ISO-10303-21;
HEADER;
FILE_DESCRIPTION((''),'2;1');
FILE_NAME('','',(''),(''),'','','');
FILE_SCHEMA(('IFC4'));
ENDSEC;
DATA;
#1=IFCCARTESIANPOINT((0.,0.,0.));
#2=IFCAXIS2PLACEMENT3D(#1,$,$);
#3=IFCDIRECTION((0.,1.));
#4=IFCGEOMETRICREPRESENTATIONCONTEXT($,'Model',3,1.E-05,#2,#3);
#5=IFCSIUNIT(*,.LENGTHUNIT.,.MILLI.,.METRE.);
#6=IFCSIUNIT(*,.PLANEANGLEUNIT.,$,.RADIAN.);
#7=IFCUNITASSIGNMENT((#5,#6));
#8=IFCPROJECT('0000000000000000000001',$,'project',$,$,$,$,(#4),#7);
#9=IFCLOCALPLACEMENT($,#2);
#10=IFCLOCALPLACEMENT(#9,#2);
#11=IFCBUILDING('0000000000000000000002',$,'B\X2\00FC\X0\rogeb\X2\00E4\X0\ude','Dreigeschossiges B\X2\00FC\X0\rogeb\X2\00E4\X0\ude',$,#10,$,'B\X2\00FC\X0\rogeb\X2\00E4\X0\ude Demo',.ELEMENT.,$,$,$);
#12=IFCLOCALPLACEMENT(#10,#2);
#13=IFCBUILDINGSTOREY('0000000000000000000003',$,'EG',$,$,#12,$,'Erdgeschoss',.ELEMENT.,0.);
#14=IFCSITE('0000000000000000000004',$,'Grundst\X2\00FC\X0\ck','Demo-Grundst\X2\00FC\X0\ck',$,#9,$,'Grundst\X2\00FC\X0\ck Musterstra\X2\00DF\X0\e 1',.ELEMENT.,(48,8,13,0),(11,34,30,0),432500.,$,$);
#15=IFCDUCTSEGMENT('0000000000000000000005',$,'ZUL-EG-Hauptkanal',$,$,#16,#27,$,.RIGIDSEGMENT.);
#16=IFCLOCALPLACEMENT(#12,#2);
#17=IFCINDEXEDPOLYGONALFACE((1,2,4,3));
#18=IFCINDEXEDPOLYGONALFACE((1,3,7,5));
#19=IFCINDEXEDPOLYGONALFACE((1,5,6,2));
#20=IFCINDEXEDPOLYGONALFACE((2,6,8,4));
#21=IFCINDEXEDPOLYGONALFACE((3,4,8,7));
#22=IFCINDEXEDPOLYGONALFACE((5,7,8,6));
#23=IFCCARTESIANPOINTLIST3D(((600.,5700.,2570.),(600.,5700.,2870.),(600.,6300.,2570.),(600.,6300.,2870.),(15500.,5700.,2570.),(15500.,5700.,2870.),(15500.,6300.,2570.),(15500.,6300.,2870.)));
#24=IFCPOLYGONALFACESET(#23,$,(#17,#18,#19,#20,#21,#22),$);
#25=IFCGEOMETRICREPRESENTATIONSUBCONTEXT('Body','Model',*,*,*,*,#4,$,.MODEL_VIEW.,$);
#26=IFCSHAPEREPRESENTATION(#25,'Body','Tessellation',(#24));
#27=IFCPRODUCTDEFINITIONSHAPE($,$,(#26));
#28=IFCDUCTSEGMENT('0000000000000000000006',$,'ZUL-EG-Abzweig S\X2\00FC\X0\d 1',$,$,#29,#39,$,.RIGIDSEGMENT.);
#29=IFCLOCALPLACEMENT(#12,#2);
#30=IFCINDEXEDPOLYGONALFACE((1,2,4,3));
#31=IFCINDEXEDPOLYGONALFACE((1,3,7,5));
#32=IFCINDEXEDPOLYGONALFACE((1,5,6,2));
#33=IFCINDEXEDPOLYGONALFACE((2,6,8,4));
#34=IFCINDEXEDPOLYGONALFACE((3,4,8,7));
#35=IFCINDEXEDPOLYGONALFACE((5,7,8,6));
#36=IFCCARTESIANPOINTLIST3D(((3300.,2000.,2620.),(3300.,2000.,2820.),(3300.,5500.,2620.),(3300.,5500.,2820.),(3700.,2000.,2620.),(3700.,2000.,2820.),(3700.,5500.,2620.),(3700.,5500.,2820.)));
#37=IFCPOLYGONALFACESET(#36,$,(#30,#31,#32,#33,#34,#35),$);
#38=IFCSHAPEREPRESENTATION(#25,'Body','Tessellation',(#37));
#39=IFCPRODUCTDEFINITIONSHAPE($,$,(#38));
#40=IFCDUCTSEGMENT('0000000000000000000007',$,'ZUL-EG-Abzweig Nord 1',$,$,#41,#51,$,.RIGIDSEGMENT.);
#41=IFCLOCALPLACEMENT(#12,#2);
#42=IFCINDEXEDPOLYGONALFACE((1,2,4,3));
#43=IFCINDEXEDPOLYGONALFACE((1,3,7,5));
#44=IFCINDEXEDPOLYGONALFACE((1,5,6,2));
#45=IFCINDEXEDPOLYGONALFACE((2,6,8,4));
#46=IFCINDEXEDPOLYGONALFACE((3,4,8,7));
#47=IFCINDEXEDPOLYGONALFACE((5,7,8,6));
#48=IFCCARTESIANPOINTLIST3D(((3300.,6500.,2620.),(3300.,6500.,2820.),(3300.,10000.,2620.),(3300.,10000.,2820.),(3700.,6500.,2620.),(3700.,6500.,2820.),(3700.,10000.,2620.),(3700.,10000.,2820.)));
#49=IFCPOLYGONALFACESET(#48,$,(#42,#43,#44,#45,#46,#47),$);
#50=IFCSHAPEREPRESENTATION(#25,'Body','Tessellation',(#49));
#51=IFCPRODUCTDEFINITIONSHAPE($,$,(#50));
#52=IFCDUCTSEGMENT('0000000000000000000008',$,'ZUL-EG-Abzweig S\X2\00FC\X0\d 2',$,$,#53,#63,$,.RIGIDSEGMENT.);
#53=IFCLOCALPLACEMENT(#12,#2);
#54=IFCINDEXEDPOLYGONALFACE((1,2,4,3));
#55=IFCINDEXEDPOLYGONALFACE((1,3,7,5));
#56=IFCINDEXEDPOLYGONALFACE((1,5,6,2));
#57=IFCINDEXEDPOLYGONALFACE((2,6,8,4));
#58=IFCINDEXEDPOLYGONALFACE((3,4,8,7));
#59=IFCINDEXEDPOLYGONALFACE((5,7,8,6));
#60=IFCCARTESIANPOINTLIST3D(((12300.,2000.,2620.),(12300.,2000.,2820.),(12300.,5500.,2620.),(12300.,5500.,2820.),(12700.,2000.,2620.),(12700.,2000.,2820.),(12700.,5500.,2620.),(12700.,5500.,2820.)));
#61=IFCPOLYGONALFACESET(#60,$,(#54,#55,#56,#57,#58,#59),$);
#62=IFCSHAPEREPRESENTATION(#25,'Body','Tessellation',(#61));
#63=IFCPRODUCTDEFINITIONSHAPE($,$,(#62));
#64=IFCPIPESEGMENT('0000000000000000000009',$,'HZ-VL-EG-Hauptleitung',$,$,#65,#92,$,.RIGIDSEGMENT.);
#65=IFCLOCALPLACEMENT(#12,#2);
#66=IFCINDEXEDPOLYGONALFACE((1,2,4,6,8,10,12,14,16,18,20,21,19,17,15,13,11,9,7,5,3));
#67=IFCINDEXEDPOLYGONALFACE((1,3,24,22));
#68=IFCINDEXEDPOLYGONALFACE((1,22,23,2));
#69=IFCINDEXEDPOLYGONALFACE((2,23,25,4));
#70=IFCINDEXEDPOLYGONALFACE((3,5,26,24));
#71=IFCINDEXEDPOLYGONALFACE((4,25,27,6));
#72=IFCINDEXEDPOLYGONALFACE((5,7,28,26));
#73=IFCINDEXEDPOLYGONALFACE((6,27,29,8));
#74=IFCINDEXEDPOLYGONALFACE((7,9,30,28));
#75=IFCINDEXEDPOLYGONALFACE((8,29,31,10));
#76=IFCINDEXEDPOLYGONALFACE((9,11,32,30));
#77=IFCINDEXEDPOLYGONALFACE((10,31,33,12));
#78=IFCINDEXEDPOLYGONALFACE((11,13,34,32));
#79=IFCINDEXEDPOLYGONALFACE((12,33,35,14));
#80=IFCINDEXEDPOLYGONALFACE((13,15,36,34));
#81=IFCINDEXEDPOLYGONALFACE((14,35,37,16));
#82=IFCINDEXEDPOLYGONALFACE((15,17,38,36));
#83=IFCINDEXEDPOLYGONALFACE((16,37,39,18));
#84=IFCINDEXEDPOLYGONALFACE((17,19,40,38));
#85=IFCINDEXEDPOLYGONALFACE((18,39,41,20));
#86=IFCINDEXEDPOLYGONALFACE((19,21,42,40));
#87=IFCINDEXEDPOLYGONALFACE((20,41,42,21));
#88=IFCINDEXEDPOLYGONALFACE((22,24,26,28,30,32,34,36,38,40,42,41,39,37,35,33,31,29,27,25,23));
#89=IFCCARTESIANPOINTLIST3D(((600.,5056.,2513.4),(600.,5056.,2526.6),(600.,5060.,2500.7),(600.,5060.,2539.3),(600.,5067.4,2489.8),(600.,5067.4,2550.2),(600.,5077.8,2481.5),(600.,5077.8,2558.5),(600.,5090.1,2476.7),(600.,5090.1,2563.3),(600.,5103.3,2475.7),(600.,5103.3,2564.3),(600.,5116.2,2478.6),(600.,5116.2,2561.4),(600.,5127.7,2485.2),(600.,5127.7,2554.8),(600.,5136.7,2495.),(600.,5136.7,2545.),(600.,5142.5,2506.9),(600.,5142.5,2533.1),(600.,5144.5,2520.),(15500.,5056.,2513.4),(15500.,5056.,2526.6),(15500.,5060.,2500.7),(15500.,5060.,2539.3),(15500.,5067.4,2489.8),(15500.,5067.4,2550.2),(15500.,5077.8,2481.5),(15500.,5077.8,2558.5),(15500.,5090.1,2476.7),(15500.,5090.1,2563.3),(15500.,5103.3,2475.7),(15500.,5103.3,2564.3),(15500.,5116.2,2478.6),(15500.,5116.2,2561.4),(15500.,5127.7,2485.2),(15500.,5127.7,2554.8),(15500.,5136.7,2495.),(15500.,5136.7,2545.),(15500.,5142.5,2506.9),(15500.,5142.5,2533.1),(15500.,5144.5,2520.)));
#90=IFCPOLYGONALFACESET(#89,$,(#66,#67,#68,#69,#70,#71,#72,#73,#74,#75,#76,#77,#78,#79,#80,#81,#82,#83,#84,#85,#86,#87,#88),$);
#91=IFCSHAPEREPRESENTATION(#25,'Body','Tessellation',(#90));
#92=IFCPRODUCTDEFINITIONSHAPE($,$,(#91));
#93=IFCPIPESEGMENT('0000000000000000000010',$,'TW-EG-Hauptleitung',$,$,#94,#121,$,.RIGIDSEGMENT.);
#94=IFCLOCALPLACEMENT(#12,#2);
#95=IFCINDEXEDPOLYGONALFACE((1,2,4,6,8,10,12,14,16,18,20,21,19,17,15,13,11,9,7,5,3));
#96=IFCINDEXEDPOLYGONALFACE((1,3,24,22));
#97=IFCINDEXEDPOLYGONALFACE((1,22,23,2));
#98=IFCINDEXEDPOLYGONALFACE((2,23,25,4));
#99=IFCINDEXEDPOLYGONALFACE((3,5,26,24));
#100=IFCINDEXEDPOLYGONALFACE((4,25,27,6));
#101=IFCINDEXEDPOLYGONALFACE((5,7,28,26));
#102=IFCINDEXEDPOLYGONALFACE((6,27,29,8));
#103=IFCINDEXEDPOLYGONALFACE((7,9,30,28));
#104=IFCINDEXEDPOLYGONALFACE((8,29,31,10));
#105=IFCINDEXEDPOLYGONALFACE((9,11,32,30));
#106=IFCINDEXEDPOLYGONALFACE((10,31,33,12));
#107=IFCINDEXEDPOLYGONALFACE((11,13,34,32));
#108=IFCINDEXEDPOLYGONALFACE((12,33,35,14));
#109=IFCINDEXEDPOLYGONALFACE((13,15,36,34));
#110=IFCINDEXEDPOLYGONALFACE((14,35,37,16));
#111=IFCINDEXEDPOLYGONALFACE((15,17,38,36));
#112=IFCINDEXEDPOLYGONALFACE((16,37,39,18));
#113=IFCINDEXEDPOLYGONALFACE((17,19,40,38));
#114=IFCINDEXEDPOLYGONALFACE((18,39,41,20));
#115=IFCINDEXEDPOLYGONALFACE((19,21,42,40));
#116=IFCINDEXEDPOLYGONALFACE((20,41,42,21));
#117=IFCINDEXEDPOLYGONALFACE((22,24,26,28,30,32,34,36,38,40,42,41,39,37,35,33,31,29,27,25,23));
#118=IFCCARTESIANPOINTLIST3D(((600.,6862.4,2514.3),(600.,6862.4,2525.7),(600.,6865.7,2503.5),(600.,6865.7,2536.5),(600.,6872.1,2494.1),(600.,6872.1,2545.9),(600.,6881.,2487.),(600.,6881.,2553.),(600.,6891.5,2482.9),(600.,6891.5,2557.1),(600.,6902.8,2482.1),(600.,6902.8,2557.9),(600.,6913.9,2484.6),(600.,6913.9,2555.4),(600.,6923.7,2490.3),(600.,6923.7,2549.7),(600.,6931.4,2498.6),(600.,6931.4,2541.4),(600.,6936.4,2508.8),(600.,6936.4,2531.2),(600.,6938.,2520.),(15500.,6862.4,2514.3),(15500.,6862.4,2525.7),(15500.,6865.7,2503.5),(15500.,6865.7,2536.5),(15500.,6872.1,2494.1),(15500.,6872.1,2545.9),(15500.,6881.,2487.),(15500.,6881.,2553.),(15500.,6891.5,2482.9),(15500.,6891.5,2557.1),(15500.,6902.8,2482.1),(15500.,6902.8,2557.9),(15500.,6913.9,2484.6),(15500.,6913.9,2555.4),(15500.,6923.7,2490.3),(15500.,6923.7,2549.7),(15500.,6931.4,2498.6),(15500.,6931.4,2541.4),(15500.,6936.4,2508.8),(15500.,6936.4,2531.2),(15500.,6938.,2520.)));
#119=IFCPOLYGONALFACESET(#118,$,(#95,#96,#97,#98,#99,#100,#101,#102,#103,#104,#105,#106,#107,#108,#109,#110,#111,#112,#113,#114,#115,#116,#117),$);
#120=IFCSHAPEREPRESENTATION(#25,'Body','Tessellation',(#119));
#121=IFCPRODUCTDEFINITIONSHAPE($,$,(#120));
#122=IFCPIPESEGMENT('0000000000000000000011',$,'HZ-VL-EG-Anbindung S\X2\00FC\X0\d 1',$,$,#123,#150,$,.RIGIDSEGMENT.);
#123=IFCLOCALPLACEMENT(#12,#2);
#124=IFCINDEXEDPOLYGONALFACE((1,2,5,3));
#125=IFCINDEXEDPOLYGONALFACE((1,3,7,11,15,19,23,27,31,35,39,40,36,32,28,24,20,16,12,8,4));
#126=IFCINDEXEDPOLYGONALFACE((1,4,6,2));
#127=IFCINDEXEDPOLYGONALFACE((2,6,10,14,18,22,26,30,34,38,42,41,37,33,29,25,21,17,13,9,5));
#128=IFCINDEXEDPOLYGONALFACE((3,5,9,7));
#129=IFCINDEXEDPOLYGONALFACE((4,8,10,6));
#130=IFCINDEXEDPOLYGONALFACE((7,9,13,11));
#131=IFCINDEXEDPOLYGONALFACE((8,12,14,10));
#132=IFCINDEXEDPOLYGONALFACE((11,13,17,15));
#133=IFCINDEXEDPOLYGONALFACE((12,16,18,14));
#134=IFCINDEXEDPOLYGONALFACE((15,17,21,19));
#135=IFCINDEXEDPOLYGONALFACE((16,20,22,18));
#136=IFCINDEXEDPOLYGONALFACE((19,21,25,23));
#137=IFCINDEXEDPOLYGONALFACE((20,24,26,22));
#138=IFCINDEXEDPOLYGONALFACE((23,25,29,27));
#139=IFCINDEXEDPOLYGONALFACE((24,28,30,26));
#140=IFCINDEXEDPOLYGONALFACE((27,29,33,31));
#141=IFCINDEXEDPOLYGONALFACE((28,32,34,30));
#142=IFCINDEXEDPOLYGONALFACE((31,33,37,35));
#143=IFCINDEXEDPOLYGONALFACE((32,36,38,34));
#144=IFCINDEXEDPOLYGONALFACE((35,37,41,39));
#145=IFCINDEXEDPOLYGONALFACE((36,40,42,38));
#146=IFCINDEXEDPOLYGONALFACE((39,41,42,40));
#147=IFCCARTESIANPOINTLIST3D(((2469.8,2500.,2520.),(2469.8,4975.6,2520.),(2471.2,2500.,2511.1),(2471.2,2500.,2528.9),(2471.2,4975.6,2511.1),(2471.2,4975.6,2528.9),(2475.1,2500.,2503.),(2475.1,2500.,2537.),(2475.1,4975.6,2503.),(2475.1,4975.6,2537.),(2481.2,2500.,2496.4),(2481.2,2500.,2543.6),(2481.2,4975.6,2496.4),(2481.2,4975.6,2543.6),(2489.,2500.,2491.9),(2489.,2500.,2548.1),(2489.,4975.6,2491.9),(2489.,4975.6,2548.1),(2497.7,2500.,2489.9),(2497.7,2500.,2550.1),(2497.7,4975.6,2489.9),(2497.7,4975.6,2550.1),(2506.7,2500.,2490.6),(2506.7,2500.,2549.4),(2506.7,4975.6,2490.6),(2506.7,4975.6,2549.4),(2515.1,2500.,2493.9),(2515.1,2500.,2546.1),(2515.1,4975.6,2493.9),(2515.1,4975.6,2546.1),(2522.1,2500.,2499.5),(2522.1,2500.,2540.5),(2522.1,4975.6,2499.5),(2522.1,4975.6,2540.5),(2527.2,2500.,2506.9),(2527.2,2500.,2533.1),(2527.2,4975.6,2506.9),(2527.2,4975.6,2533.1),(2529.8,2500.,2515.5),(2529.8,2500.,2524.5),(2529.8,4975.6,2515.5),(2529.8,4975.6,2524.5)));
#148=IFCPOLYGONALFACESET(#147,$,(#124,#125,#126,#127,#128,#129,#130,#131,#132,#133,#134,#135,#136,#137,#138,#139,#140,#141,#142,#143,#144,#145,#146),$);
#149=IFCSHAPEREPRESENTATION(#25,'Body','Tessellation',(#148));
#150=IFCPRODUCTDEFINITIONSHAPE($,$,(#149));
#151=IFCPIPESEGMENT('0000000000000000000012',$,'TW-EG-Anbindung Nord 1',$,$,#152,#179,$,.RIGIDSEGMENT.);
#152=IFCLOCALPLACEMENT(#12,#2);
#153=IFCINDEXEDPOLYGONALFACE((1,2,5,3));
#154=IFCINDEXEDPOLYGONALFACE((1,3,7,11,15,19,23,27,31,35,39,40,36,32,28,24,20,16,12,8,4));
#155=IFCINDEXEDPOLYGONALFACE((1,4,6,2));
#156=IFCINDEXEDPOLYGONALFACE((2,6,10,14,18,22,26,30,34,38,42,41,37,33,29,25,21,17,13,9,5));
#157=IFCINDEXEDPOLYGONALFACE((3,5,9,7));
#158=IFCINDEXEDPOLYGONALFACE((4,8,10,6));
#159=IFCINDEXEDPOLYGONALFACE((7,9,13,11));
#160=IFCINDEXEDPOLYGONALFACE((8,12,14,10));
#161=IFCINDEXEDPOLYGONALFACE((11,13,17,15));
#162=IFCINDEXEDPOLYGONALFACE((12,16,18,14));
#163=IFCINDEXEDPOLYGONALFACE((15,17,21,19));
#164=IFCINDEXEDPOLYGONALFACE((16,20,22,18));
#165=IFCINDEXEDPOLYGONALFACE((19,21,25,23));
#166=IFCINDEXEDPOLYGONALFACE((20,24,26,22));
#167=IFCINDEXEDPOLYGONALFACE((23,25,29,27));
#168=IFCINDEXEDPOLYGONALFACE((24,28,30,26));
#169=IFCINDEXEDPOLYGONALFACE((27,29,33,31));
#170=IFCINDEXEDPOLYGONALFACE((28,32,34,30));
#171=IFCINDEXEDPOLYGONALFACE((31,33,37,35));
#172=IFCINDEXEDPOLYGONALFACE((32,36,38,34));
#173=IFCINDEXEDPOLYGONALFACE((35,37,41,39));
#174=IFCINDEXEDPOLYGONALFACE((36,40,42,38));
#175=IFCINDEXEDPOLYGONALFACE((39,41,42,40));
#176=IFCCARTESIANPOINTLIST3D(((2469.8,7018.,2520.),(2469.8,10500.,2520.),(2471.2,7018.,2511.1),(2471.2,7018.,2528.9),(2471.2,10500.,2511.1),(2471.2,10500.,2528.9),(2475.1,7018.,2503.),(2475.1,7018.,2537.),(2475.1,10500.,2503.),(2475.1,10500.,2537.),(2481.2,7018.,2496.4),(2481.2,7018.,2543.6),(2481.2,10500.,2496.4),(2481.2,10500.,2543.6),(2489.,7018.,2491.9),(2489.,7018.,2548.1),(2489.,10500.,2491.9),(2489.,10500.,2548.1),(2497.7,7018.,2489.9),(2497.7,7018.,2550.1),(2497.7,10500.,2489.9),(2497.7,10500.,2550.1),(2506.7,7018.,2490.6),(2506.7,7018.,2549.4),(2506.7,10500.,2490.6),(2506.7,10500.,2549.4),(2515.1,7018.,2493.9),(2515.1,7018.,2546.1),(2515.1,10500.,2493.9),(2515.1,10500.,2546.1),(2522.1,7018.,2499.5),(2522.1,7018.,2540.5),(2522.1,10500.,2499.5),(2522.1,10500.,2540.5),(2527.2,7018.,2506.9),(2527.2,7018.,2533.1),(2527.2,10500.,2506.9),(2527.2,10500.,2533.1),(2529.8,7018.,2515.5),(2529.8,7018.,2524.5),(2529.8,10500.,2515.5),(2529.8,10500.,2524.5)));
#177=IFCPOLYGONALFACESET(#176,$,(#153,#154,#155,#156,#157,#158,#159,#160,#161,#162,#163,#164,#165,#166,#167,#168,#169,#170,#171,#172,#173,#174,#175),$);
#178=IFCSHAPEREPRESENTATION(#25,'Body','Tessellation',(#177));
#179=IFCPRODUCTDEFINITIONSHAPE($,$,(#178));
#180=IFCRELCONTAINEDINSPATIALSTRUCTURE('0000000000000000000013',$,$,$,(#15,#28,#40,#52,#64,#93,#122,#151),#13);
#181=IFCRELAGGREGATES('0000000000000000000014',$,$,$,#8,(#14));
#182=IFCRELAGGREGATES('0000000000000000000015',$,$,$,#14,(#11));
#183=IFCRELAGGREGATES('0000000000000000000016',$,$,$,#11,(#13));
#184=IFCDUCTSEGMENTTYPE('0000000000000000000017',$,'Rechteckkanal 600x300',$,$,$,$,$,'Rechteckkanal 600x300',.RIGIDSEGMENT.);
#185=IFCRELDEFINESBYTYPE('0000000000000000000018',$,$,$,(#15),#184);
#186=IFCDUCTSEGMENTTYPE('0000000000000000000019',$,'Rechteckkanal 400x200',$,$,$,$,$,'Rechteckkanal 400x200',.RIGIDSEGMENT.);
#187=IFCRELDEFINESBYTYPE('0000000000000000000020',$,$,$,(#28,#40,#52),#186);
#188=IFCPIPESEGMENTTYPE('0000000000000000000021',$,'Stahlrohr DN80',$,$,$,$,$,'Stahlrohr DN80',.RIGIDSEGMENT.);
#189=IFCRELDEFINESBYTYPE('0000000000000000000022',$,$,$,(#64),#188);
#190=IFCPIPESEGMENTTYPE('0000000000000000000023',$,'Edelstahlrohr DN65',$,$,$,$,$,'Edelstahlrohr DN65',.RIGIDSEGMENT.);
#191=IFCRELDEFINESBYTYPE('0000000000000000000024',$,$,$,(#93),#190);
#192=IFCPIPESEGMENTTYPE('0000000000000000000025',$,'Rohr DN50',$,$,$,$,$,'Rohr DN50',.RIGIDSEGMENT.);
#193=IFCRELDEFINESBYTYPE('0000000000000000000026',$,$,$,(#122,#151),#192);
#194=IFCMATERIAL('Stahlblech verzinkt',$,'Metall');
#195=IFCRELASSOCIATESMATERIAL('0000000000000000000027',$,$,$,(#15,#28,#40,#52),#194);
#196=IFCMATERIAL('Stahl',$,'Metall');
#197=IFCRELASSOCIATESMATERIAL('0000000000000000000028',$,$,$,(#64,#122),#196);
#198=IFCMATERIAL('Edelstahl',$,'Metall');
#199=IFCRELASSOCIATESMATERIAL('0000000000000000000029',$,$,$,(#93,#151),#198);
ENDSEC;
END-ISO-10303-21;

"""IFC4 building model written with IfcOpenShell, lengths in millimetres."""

from ifc_helpers import new_model, si_unit, direction, frame, origin, origin_2d, place, context, subcontext, project, spatial, rectangle, circle, extrude, material, type_object, element, save


model = new_model("IFC4")

# Units and contexts
model_context = context("Model", 3, precision=1e-05, world=origin(), true_north=direction((0.0, 1.0)))
body_context = subcontext(model_context, "Body", "Model", "MODEL_VIEW")
ifc_project = project(units=[si_unit("LENGTHUNIT", "METRE", prefix="MILLI"), si_unit("PLANEANGLEUNIT", "RADIAN")], contexts=[model_context])

# Site, building, storey
site_placement = place(None, origin())
site = spatial("IfcSite", under=ifc_project, at=site_placement, Name="Grundstück", Description="Demo-Grundstück", LongName="Grundstück Musterstraße 1", CompositionType="ELEMENT", RefLatitude=(48, 8, 13, 0), RefLongitude=(11, 34, 30, 0), RefElevation=432500.0)
building_placement = place(site_placement, origin())
building = spatial("IfcBuilding", under=site, at=building_placement, Name="Bürogebäude", Description="Dreigeschossiges Bürogebäude", LongName="Bürogebäude Demo", CompositionType="ELEMENT")
storey_placement = place(building_placement, origin())
storey = spatial("IfcBuildingStorey", under=building, at=storey_placement, Name="EG", LongName="Erdgeschoss", CompositionType="ELEMENT", Elevation=0.0)

# Duct segments
ifc_material_1 = material(Name="Stahlblech verzinkt", Category="Metall")
duct_segment_type_1 = type_object("IfcDuctSegmentType", Name="Rechteckkanal 600x300", ElementType="Rechteckkanal 600x300", PredefinedType="RIGIDSEGMENT")
duct_segment_placement = place(storey_placement, frame((600.0, 6000.0, 2720.0)))
element("IfcDuctSegment", 1, at=duct_segment_placement, inside=storey, type_object=duct_segment_type_1, material=ifc_material_1, Name="ZUL-EG-Hauptkanal", PredefinedType="RIGIDSEGMENT", context=body_context, shape_type="SweptSolid", body=[
    extrude(rectangle(XDim=600.0, YDim=300.0, at=origin_2d()), frame((0.0, 0.0, 0.0), z_axis=(1.0, 0.0, 0.0), x_axis=(0.0, 1.0, 0.0)), (0.0, 0.0, 1.0), 14900.0),
])
duct_segment_type_2 = type_object("IfcDuctSegmentType", Name="Rechteckkanal 400x200", ElementType="Rechteckkanal 400x200", PredefinedType="RIGIDSEGMENT")
for number, where, name in (
    (2, (3500.0, 2000.0, 2720.0), "ZUL-EG-Abzweig Süd 1"),
    (3, (3500.0, 6500.0, 2720.0), "ZUL-EG-Abzweig Nord 1"),
    (4, (12500.0, 2000.0, 2720.0), "ZUL-EG-Abzweig Süd 2"),
):
    element("IfcDuctSegment", number, at=place(storey_placement, frame(where)), inside=storey, type_object=duct_segment_type_2, material=ifc_material_1, Name=name, PredefinedType="RIGIDSEGMENT", context=body_context, shape_type="SweptSolid", body=[
        extrude(rectangle(XDim=400.0, YDim=200.0, at=origin_2d()), frame((0.0, 0.0, 0.0), z_axis=(0.0, 1.0, 0.0), x_axis=(-1.0, 0.0, 0.0)), (0.0, 0.0, 1.0), 3500.0),
    ])

# Pipe segments
ifc_material_2 = material(Name="Stahl", Category="Metall")
pipe_segment_type_1 = type_object("IfcPipeSegmentType", Name="Stahlrohr DN80", ElementType="Stahlrohr DN80", PredefinedType="RIGIDSEGMENT")
pipe_segment_1_placement = place(storey_placement, frame((600.0, 5100.0, 2520.0)))
element("IfcPipeSegment", 5, at=pipe_segment_1_placement, inside=storey, type_object=pipe_segment_type_1, material=ifc_material_2, Name="HZ-VL-EG-Hauptleitung", PredefinedType="RIGIDSEGMENT", context=body_context, shape_type="SweptSolid", body=[
    extrude(circle(Radius=44.5, at=origin_2d()), frame((0.0, 0.0, 0.0), z_axis=(1.0, 0.0, 0.0), x_axis=(0.0, 1.0, 0.0)), (0.0, 0.0, 1.0), 14900.0),
])
ifc_material_3 = material(Name="Edelstahl", Category="Metall")
pipe_segment_type_2 = type_object("IfcPipeSegmentType", Name="Edelstahlrohr DN65", ElementType="Edelstahlrohr DN65", PredefinedType="RIGIDSEGMENT")
pipe_segment_2_placement = place(storey_placement, frame((600.0, 6900.0, 2520.0)))
element("IfcPipeSegment", 6, at=pipe_segment_2_placement, inside=storey, type_object=pipe_segment_type_2, material=ifc_material_3, Name="TW-EG-Hauptleitung", PredefinedType="RIGIDSEGMENT", context=body_context, shape_type="SweptSolid", body=[
    extrude(circle(Radius=38.0, at=origin_2d()), frame((0.0, 0.0, 0.0), z_axis=(1.0, 0.0, 0.0), x_axis=(0.0, 1.0, 0.0)), (0.0, 0.0, 1.0), 14900.0),
])
pipe_segment_type_3 = type_object("IfcPipeSegmentType", Name="Rohr DN50", ElementType="Rohr DN50", PredefinedType="RIGIDSEGMENT")
pipe_segment_3_placement = place(storey_placement, frame((2500.0, 2500.0, 2520.0)))
element("IfcPipeSegment", 7, at=pipe_segment_3_placement, inside=storey, type_object=pipe_segment_type_3, material=ifc_material_2, Name="HZ-VL-EG-Anbindung Süd 1", PredefinedType="RIGIDSEGMENT", context=body_context, shape_type="SweptSolid", body=[
    extrude(circle(Radius=30.1, at=origin_2d()), frame((0.0, 0.0, 0.0), z_axis=(0.0, 1.0, 0.0), x_axis=(-1.0, 0.0, 0.0)), (0.0, 0.0, 1.0), 2475.6),
])
pipe_segment_4_placement = place(storey_placement, frame((2500.0, 7018.1, 2520.0)))
element("IfcPipeSegment", 8, at=pipe_segment_4_placement, inside=storey, type_object=pipe_segment_type_3, material=ifc_material_3, Name="TW-EG-Anbindung Nord 1", PredefinedType="RIGIDSEGMENT", context=body_context, shape_type="SweptSolid", body=[
    extrude(circle(Radius=30.1, at=origin_2d()), frame((0.0, 0.0, 0.0), z_axis=(0.0, 1.0, 0.0), x_axis=(-1.0, 0.0, 0.0)), (0.0, 0.0, 1.0), 3481.9),
])

save(model, "model.ifc")
